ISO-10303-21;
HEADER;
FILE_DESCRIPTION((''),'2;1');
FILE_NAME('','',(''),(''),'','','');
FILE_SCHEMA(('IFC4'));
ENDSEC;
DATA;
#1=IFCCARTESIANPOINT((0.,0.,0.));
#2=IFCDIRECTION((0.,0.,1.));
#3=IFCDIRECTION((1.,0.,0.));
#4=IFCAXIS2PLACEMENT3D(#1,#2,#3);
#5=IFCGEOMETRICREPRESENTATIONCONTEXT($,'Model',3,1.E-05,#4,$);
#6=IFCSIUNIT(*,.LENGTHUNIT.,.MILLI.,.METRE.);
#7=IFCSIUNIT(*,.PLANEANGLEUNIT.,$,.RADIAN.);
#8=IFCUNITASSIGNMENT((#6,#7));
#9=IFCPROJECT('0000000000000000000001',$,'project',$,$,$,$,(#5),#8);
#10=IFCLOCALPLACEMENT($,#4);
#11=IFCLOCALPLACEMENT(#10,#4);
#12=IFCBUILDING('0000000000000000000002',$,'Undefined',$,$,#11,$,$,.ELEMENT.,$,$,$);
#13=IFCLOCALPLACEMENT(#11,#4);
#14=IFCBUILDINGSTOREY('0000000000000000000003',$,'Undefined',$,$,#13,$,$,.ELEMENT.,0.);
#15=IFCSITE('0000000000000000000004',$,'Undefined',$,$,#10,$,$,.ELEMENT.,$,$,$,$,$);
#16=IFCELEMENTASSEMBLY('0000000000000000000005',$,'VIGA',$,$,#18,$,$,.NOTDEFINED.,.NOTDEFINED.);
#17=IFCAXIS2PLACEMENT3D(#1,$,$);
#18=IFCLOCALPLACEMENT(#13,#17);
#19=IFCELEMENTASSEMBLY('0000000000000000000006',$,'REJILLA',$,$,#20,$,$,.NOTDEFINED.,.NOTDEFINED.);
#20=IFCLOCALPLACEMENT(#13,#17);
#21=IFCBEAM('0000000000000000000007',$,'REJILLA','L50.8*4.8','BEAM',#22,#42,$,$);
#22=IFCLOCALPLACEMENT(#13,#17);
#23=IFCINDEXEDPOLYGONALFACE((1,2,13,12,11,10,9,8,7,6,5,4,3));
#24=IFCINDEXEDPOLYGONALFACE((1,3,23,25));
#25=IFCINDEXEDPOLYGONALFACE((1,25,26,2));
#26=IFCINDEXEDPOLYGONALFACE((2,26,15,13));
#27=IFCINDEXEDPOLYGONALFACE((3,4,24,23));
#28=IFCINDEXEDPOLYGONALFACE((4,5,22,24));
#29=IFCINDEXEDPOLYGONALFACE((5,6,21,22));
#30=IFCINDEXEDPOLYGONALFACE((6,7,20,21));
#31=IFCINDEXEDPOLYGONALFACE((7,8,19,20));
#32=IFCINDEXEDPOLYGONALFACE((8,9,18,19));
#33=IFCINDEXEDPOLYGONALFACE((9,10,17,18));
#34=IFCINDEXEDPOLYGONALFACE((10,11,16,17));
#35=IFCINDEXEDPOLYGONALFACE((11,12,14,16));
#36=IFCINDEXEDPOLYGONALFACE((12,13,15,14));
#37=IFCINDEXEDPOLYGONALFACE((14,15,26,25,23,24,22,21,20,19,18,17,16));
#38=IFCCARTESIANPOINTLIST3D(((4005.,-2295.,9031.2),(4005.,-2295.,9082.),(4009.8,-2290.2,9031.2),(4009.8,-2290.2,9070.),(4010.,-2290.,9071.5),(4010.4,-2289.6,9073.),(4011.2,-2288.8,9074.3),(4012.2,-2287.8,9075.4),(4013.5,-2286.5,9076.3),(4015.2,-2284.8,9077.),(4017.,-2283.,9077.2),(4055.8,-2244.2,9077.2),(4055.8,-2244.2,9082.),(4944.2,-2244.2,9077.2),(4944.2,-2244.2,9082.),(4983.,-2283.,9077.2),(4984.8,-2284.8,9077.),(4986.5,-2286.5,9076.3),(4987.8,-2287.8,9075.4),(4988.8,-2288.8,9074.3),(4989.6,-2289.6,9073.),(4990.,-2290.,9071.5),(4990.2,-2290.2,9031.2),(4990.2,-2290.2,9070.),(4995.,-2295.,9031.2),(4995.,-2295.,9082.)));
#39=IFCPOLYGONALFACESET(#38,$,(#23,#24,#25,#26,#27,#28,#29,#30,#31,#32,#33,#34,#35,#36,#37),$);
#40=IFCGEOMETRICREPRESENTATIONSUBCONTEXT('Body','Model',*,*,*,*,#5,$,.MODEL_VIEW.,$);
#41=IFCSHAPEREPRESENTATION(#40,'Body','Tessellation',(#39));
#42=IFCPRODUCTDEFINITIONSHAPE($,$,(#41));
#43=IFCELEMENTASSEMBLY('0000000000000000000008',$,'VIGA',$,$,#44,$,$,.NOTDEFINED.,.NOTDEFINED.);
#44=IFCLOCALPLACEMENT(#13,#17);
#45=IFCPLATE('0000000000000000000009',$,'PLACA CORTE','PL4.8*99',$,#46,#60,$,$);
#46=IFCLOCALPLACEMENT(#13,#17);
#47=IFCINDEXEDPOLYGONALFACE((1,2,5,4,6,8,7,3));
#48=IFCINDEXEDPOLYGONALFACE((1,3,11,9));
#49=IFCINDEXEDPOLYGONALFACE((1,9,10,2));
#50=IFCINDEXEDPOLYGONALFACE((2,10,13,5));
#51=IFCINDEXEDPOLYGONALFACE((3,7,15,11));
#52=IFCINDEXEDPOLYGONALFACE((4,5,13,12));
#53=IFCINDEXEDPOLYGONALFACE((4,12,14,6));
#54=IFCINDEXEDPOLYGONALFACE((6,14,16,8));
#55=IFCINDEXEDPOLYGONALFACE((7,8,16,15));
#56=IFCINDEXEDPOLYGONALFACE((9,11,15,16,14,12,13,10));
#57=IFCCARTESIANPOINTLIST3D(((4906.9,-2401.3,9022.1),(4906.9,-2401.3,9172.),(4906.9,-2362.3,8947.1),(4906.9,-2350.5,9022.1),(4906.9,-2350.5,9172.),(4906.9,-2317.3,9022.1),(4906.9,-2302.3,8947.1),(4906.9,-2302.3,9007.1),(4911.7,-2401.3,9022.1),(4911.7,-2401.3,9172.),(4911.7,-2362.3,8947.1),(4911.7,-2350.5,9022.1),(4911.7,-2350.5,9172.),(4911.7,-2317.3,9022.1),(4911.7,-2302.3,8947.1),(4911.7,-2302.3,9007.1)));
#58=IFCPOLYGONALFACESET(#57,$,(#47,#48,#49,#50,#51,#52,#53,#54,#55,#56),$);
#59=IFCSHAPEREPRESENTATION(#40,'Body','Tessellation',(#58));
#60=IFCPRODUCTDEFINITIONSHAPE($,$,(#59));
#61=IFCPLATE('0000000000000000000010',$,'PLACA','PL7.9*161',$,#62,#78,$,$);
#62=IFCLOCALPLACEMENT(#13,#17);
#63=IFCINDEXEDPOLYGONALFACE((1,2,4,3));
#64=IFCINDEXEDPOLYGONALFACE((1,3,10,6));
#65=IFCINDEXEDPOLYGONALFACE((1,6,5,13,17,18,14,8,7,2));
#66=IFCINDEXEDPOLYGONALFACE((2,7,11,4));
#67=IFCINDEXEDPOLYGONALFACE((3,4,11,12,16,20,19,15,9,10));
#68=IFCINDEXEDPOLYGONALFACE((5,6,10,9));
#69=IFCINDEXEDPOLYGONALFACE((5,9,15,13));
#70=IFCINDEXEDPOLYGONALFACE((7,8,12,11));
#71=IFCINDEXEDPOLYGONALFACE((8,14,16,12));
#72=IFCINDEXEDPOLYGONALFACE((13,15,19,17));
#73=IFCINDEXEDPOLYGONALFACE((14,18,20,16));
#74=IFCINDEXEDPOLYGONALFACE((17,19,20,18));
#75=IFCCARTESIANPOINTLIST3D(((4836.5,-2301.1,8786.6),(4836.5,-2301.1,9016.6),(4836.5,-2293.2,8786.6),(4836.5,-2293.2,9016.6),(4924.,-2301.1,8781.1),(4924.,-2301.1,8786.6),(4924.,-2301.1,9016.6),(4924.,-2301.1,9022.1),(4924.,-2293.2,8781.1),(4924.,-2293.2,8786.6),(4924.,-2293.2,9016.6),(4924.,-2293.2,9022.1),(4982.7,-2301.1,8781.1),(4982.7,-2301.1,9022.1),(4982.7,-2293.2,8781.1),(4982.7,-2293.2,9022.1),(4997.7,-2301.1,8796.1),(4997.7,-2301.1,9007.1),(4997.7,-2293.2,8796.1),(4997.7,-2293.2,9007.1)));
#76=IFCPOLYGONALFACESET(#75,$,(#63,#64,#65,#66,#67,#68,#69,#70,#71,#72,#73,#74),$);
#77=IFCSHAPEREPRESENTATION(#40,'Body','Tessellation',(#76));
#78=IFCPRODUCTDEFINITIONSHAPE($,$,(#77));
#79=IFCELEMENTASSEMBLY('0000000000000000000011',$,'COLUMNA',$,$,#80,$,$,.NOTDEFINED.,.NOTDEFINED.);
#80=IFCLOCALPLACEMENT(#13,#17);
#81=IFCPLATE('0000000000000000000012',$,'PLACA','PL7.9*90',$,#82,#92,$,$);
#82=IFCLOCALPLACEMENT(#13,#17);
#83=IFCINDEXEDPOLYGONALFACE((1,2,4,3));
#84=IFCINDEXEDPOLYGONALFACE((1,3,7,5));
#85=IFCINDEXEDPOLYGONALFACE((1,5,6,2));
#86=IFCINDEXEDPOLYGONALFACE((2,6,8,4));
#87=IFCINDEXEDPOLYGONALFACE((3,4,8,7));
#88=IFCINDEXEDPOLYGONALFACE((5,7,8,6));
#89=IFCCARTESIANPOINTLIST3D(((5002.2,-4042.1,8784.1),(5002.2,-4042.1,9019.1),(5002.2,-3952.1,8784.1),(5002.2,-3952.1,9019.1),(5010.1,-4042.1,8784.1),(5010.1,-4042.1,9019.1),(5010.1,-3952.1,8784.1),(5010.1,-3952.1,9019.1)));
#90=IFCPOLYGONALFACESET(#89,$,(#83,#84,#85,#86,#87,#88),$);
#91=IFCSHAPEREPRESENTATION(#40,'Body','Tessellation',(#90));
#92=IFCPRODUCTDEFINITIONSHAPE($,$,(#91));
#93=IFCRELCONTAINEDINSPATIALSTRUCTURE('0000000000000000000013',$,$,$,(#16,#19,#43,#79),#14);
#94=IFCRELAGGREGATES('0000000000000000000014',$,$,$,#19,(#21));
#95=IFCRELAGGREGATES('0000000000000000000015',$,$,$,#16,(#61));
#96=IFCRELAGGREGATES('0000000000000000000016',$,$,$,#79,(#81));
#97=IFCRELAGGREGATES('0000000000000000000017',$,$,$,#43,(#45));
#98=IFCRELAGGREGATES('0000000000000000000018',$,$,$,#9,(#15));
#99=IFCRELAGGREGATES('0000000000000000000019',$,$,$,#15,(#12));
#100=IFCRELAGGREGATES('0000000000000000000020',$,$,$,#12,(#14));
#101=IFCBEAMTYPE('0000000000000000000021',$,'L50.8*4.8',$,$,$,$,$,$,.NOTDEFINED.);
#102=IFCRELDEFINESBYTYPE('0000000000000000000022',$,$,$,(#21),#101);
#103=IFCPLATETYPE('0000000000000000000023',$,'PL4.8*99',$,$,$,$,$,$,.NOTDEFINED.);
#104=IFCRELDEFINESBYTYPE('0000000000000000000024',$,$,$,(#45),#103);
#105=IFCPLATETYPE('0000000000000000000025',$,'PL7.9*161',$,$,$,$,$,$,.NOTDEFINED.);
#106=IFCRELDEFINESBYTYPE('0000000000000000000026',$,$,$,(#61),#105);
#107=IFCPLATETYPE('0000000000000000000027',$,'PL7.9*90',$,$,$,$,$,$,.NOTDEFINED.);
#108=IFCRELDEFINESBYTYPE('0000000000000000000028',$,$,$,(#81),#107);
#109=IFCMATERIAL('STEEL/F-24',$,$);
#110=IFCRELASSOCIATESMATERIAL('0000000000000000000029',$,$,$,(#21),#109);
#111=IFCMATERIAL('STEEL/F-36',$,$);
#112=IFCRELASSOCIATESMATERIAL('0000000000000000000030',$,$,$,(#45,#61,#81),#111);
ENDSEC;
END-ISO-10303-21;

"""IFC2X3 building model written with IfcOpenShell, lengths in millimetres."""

from ifc_helpers import new_model, si_unit, frame, origin_with_axes, origin_2d_with_axis, place, context, subcontext, project, spatial, polyline, l_section, outline, extrude, clip, halfspace, material, type_object, element, aggregate, save


model = new_model("IFC2X3")

# Units and contexts
model_context = context("Model", 3, precision=1e-05, world=origin_with_axes())
body_context = subcontext(model_context, "Body", "Model", "MODEL_VIEW")
ifc_project = project(units=[si_unit("LENGTHUNIT", "METRE", prefix="MILLI"), si_unit("PLANEANGLEUNIT", "RADIAN")], contexts=[model_context])

# Site, building, storey
site_placement = place(None, origin_with_axes())
site = spatial("IfcSite", under=ifc_project, at=site_placement, Name="Undefined", CompositionType="ELEMENT")
building_placement = place(site_placement, origin_with_axes())
building = spatial("IfcBuilding", under=site, at=building_placement, Name="Undefined", CompositionType="ELEMENT")
storey_placement = place(building_placement, origin_with_axes())
storey = spatial("IfcBuildingStorey", under=building, at=storey_placement, Name="Undefined", CompositionType="ELEMENT", Elevation=0.0)

# Shared definitions
ifc_material_1 = material(Name="STEEL/F-24")

# Element assembly
assembly_1_placement = place(storey_placement, origin_with_axes())
assembly_1 = element("IfcElementAssembly", 1, at=assembly_1_placement, inside=storey, Name="VIGA", AssemblyPlace="NOTDEFINED", PredefinedType="NOTDEFINED")
ifc_material_2 = material(Name="STEEL/F-36")

# Element assembly, beam
assembly_2_placement = place(storey_placement, origin_with_axes())
assembly_2 = element("IfcElementAssembly", 2, at=assembly_2_placement, inside=storey, Name="REJILLA", AssemblyPlace="NOTDEFINED", PredefinedType="NOTDEFINED")
beam_type_1 = type_object("IfcBeamType", Name="L50.8*4.8", PredefinedType="NOTDEFINED")
beam_1_placement = place(assembly_2_placement, frame((4005.0, -2269.6, 9056.6), z_axis=(0.0, 0.0, -1.0), x_axis=(1.0, 0.0, 0.0)))
beam_1 = element("IfcBeam", 3, at=beam_1_placement, type_object=beam_type_1, material=ifc_material_1, Name="REJILLA", Description="L50.8*4.8", ObjectType="BEAM", context=body_context, shape_type="Clipping", body=[
    clip(clip(extrude(l_section(Depth=50.8, Width=50.8, Thickness=4.8, FilletRadius=7.2, at=origin_2d_with_axis()), frame((1015.9, 0.0, 0.0), z_axis=(-1.0, 0.0, 0.0), x_axis=(0.0, -1.0, 0.0)), (0.0, 0.0, 1.0), 1041.8), halfspace(frame((939.2, -25.4, 0.0), z_axis=(-0.707107, 0.707107, 0.0), x_axis=(0.0, 0.0, -1.0)), True)), halfspace(frame((50.8, -25.4, 0.0), z_axis=(-0.707107, -0.707107, 0.0), x_axis=(0.0, 0.0, -1.0)), False)),
])
aggregate(assembly_2, [beam_1])

# Element assembly, plate
assembly_3_placement = place(storey_placement, origin_with_axes())
assembly_3 = element("IfcElementAssembly", 4, at=assembly_3_placement, inside=storey, Name="VIGA", AssemblyPlace="NOTDEFINED", PredefinedType="NOTDEFINED")
plate_type_1 = type_object("IfcPlateType", Name="PL4.8*99", PredefinedType="NOTDEFINED")
plate_1_placement = place(assembly_3_placement, frame((4909.3, -2302.3, 8947.1), z_axis=(-1.0, 0.0, 0.000038), x_axis=(0.0, -1.0, 0.0)))
plate_1 = element("IfcPlate", 5, at=plate_1_placement, type_object=plate_type_1, material=ifc_material_2, Name="PLACA CORTE", Description="PL4.8*99", context=body_context, shape_type="SweptSolid", body=[
    extrude(outline(polyline([(0.0, 0.0), (60.0, 0.0), (99.1, 75.0), (99.1, 224.9), (48.3, 224.9), (48.2, 75.0), (15.0, 75.0), (0.0, 60.0), (0.0, 0.0)])), frame((0.0, 0.0, -2.4), z_axis=(0.0, 0.0, 1.0), x_axis=(1.0, 0.0, 0.0)), (0.0, 0.0, 1.0), 4.8),
])

# Plate
plate_type_2 = type_object("IfcPlateType", Name="PL7.9*161", PredefinedType="NOTDEFINED")
plate_2_placement = place(assembly_1_placement, frame((4997.7, -2297.2, 9022.1), z_axis=(0.0, -1.0, 0.0), x_axis=(-1.0, 0.0, 0.0)))
plate_2 = element("IfcPlate", 6, at=plate_2_placement, type_object=plate_type_2, material=ifc_material_2, Name="PLACA", Description="PL7.9*161", context=body_context, shape_type="SweptSolid", body=[
    extrude(outline(polyline([(0.0, 15.0), (15.0, 0.0), (73.7, 0.0), (73.7, 5.5), (161.2, 5.5), (161.2, 235.5), (73.7, 235.5), (73.7, 241.0), (15.0, 241.0), (0.0, 226.0), (0.0, 15.0)])), frame((0.0, 0.0, -4.0), z_axis=(0.0, 0.0, 1.0), x_axis=(1.0, 0.0, 0.0)), (0.0, 0.0, 1.0), 7.9),
])
aggregate(assembly_1, [plate_2])

# Element assembly, plate
assembly_4_placement = place(storey_placement, origin_with_axes())
assembly_4 = element("IfcElementAssembly", 7, at=assembly_4_placement, inside=storey, Name="COLUMNA", AssemblyPlace="NOTDEFINED", PredefinedType="NOTDEFINED")
plate_type_3 = type_object("IfcPlateType", Name="PL7.9*90", PredefinedType="NOTDEFINED")
plate_3_placement = place(assembly_4_placement, frame((5006.2, -3952.1, 9019.1), z_axis=(-1.0, 0.0, 0.0), x_axis=(0.0, 0.0, -1.0)))
plate_3 = element("IfcPlate", 8, at=plate_3_placement, type_object=plate_type_3, material=ifc_material_2, Name="PLACA", Description="PL7.9*90", context=body_context, shape_type="SweptSolid", body=[
    extrude(outline(polyline([(0.0, 0.0), (235.0, 0.0), (235.0, 90.0), (0.0, 90.0), (0.0, 0.0)])), frame((0.0, 0.0, -4.0), z_axis=(0.0, 0.0, 1.0), x_axis=(1.0, 0.0, 0.0)), (0.0, 0.0, 1.0), 7.9),
])
aggregate(assembly_4, [plate_3])

aggregate(assembly_3, [plate_1])

save(model, "model.ifc")
